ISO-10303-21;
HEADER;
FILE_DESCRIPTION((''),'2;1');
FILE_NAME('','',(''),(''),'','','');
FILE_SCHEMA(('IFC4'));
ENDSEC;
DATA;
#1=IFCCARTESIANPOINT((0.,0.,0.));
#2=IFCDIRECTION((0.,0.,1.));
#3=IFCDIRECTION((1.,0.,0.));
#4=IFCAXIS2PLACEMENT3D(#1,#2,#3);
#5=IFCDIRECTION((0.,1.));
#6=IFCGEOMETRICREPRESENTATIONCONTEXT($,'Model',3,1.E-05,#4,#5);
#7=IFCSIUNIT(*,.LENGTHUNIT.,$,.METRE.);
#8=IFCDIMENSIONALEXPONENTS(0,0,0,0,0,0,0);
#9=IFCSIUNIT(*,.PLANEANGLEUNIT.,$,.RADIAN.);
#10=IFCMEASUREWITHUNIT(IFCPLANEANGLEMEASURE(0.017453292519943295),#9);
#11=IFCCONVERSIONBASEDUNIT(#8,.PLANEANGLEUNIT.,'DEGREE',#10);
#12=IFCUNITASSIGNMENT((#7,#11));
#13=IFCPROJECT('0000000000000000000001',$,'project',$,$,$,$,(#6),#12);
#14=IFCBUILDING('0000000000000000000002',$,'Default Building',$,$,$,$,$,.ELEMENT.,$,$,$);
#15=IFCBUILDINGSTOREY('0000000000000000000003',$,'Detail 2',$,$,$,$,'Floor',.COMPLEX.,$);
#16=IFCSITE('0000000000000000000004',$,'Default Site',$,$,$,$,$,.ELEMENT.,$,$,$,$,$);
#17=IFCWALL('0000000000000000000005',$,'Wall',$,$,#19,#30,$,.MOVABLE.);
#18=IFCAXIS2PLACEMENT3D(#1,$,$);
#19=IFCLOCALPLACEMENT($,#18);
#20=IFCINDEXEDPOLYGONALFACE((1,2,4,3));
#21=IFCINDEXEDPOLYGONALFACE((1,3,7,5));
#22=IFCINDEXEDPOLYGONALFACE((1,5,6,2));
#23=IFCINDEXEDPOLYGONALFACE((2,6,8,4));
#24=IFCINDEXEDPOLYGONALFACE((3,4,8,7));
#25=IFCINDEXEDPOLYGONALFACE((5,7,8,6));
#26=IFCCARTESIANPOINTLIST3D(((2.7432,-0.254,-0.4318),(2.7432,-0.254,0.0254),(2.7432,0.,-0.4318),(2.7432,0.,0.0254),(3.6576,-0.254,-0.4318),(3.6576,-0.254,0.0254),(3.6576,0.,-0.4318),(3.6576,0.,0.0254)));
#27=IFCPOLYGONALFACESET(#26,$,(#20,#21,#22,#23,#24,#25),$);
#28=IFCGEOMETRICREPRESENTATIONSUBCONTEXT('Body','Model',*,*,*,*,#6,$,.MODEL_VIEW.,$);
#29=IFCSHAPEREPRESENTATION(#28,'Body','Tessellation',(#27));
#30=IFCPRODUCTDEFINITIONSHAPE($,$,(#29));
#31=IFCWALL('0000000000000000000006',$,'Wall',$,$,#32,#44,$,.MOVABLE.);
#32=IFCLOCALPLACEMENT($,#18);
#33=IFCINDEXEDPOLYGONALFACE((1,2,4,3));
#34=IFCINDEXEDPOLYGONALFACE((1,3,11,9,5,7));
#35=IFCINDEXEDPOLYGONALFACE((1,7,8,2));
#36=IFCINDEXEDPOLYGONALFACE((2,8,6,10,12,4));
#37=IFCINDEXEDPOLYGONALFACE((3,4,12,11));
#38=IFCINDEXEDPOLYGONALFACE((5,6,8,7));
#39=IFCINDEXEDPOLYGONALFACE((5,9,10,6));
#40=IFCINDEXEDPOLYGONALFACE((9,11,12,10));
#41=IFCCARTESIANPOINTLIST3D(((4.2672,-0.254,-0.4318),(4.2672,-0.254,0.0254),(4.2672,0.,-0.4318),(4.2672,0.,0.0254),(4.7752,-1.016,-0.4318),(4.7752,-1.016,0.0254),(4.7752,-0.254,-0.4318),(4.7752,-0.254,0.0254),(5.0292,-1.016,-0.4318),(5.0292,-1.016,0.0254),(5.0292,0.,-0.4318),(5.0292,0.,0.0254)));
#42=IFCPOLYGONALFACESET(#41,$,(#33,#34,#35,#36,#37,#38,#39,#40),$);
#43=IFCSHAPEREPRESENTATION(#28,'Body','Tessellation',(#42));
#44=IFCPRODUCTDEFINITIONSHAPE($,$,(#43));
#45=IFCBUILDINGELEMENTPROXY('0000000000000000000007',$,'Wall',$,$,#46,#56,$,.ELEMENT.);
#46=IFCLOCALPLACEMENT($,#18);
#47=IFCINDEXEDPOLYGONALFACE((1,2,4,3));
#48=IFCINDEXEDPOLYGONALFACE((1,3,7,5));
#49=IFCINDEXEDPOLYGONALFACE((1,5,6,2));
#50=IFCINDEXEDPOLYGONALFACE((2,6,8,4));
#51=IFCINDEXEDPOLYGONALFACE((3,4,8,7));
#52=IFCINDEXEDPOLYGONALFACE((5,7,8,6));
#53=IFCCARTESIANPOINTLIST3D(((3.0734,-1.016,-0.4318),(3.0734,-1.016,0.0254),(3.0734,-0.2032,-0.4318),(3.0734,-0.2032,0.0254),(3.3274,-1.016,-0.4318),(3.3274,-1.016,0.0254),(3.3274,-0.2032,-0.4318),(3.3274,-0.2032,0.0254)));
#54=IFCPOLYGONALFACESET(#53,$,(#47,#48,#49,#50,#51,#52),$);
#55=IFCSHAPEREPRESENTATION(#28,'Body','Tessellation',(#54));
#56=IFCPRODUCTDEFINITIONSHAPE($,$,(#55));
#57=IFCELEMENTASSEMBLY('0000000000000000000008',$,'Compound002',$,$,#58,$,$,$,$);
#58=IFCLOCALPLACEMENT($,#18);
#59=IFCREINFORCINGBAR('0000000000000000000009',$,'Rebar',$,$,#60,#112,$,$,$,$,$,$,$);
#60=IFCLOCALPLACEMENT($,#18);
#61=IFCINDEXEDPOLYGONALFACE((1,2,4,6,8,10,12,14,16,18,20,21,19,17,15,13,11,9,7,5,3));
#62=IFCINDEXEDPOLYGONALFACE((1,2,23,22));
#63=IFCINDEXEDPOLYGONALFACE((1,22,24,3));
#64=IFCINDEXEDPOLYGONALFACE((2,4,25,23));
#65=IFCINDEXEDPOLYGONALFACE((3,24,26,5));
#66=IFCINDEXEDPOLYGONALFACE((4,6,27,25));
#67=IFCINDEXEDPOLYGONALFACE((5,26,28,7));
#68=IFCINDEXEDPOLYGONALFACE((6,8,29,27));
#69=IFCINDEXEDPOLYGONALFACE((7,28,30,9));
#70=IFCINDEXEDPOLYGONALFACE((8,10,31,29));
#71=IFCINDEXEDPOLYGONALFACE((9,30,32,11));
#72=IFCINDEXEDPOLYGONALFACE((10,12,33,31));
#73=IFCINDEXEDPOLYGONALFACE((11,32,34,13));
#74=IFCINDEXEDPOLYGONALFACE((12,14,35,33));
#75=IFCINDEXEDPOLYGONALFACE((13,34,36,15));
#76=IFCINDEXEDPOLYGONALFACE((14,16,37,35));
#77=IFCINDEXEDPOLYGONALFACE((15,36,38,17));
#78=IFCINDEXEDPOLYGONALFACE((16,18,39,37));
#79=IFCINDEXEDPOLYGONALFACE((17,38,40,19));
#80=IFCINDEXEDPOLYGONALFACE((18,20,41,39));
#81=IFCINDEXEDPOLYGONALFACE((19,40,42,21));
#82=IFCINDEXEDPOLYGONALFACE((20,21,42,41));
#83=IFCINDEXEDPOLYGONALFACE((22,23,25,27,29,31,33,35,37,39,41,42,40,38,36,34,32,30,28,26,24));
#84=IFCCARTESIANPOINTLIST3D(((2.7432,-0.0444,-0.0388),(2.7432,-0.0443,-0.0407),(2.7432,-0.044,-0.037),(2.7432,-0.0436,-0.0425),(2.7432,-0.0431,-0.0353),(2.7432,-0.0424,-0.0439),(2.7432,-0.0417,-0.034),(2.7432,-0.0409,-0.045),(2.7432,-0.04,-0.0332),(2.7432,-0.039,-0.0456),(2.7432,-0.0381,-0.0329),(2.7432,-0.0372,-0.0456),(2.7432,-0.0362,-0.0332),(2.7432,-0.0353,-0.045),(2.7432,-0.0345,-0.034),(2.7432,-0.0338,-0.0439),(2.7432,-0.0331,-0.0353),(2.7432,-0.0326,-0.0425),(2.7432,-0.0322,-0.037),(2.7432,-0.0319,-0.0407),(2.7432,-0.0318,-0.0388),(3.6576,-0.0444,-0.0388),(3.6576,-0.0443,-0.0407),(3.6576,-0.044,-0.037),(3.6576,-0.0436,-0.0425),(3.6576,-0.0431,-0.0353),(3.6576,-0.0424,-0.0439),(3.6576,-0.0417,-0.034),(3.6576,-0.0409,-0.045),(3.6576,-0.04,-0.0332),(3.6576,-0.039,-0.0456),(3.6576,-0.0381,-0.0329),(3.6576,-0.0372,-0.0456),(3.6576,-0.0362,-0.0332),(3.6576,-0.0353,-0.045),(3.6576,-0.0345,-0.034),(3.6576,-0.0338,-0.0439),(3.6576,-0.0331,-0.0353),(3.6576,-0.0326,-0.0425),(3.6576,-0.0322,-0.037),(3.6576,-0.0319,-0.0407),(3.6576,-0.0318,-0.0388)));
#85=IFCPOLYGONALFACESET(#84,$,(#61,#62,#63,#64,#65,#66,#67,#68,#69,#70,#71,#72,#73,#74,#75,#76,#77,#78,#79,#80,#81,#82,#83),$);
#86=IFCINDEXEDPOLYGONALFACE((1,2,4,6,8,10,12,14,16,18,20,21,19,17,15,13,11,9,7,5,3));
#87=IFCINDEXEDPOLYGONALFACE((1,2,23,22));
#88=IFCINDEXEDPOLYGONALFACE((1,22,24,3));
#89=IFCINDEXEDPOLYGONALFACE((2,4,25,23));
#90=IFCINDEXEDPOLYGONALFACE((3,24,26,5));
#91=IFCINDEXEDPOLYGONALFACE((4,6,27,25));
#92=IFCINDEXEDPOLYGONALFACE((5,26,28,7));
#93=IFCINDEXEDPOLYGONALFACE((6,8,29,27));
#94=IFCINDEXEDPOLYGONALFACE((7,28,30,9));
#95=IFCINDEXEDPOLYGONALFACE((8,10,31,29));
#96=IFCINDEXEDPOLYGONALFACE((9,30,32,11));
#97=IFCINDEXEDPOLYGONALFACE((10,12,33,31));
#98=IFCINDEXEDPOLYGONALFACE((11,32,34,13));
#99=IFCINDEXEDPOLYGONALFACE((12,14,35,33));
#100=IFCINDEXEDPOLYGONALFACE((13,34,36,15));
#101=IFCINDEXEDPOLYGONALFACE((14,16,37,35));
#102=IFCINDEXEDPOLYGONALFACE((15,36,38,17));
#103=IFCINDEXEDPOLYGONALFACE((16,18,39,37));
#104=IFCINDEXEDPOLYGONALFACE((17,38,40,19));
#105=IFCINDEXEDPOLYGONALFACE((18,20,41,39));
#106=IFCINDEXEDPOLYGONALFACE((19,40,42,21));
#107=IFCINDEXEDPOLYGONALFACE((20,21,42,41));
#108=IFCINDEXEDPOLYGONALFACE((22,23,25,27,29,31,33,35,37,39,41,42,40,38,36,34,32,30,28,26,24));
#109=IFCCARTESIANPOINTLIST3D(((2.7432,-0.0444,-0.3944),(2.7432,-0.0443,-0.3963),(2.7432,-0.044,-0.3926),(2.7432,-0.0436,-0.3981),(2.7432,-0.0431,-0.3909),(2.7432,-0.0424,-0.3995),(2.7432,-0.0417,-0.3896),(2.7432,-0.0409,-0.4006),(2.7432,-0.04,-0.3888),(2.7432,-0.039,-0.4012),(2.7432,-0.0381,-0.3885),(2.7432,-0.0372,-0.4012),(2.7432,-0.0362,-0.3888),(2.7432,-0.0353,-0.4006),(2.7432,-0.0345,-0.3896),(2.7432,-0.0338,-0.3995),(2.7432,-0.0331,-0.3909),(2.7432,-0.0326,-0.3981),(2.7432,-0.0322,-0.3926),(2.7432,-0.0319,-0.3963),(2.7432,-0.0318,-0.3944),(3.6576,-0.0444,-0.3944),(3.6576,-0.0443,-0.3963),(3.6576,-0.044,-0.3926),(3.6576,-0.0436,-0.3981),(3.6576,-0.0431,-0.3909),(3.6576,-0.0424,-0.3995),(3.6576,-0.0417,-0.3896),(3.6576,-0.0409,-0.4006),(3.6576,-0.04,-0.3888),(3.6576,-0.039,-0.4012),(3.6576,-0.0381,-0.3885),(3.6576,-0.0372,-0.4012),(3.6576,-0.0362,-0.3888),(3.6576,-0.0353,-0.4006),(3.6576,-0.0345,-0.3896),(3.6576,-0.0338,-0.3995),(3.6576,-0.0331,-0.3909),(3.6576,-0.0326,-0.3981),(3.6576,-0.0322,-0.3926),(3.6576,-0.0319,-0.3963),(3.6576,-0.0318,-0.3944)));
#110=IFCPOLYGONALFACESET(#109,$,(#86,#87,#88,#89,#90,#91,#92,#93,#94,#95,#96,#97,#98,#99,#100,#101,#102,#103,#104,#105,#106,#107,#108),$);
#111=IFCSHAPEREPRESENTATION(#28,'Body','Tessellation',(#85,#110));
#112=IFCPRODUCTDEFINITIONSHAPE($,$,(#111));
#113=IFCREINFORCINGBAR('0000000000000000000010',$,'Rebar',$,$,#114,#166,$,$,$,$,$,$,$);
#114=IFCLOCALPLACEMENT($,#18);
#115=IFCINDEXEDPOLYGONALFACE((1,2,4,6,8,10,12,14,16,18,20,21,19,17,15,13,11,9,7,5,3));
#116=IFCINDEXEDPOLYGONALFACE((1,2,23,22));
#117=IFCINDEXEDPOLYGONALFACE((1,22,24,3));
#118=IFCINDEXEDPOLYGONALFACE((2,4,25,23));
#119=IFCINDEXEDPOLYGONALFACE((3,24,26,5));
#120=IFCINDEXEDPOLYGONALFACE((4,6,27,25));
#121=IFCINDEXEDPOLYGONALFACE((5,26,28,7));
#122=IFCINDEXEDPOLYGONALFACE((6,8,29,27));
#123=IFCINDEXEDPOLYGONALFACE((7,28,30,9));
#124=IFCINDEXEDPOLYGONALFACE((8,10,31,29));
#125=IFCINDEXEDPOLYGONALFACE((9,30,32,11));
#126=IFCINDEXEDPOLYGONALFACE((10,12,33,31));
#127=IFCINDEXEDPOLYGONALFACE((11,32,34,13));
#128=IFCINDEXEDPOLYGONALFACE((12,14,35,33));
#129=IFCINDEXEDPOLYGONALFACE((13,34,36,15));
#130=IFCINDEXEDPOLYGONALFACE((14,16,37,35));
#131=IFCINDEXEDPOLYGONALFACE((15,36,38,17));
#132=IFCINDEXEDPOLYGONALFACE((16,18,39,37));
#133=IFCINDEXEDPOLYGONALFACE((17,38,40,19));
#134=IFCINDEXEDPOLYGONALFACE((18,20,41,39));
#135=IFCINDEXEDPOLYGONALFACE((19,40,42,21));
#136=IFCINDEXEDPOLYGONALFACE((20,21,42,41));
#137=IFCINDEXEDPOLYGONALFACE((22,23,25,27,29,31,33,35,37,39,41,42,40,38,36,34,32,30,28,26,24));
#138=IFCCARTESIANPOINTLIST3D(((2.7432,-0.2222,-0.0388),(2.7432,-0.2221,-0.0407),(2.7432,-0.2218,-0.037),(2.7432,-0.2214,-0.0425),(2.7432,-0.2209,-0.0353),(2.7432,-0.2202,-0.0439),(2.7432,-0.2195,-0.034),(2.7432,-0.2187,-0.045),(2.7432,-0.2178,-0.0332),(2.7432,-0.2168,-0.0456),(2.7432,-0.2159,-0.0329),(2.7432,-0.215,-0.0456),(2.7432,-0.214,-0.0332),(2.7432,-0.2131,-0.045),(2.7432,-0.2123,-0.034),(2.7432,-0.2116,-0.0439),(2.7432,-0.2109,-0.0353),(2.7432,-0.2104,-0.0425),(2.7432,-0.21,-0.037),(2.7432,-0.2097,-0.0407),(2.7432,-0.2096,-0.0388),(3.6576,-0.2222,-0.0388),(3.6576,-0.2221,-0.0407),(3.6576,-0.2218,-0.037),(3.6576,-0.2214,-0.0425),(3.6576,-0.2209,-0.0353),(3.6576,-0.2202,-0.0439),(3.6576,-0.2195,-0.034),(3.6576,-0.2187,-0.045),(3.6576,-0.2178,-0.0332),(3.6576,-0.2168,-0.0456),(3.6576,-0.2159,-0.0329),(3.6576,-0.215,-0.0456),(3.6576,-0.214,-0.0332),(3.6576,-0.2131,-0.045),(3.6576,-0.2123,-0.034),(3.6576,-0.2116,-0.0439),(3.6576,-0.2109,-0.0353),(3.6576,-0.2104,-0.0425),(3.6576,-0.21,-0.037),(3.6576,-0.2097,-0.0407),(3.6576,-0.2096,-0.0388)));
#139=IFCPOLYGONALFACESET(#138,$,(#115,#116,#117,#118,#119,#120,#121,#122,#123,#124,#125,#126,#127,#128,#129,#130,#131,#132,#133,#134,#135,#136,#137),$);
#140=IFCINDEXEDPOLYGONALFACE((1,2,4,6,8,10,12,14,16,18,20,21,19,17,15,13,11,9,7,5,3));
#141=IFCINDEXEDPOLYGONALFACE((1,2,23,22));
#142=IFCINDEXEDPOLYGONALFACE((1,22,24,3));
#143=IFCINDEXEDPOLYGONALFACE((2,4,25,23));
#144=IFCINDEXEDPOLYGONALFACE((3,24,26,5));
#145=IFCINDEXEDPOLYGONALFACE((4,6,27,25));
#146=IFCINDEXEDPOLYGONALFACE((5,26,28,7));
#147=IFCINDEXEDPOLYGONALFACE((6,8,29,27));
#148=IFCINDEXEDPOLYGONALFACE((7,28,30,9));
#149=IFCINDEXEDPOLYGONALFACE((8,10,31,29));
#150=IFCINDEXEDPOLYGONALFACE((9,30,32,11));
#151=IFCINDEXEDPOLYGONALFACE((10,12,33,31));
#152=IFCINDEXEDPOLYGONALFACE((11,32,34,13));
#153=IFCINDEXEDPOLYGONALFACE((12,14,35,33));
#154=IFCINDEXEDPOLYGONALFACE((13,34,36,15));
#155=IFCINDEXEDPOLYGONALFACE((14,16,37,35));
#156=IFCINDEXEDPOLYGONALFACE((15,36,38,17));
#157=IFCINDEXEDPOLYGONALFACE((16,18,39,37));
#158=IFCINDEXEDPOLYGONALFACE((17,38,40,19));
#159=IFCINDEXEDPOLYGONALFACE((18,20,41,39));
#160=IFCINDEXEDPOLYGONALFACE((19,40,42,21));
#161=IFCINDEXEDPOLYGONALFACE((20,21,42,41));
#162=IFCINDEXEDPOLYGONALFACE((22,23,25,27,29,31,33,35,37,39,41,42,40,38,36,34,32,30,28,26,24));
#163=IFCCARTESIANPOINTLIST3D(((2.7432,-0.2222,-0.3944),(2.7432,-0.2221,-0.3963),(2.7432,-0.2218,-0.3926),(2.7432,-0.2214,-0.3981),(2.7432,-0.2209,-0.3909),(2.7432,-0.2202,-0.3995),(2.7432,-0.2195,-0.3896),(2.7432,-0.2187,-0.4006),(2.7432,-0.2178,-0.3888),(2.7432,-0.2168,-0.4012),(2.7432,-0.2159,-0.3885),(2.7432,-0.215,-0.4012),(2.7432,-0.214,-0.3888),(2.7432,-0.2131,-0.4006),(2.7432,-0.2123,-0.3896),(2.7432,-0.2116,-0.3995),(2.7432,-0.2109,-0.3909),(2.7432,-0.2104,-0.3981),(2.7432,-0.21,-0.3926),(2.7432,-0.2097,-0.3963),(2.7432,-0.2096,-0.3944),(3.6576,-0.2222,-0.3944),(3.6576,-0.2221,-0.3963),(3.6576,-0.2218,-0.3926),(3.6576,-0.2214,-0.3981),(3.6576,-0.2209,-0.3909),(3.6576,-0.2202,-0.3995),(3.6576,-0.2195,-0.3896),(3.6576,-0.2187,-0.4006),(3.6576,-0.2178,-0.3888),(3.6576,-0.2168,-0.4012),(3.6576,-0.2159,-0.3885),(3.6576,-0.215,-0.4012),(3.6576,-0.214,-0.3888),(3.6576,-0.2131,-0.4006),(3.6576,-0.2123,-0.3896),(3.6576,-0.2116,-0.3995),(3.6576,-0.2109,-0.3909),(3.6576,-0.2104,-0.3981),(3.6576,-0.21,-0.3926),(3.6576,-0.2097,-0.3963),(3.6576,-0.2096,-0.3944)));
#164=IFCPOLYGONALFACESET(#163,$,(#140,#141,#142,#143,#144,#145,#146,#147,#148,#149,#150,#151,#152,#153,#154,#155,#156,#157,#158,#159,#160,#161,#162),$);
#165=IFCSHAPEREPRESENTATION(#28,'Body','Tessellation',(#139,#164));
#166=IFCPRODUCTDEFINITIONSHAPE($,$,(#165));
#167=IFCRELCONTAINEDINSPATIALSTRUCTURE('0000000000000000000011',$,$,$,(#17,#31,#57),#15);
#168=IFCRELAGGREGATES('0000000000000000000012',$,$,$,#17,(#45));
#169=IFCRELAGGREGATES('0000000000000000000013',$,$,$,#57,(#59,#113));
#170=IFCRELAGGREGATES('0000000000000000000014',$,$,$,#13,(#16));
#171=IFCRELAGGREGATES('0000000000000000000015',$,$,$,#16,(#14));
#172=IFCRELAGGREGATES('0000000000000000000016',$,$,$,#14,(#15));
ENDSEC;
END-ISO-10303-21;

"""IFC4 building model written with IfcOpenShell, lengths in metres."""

from ifc_helpers import new_model, entity, si_unit, converted_unit, direction, frame, frame_2d, origin_with_axes, origin_2d_with_axis, place, context, subcontext, project, spatial, polyline, rectangle, outline, extrude, element, aggregate, save


model = new_model("IFC4")

# Units and contexts
model_context = context("Model", 3, precision=1e-05, world=origin_with_axes(), true_north=direction((0.0, 1.0)))
body_context = subcontext(model_context, "Body", "Model", "MODEL_VIEW")
ifc_project = project(units=[si_unit("LENGTHUNIT", "METRE"), converted_unit("PLANEANGLEUNIT", "DEGREE", entity("IfcPlaneAngleMeasure", 0.017453292519943295), si_unit("PLANEANGLEUNIT", "RADIAN"), dimensions=[0, 0, 0, 0, 0, 0, 0])], contexts=[model_context])

# Site, building, storey
site = spatial("IfcSite", under=ifc_project, Name="Default Site", CompositionType="ELEMENT")
building = spatial("IfcBuilding", under=site, Name="Default Building", CompositionType="ELEMENT")
storey = spatial("IfcBuildingStorey", under=building, Name="Detail 2", LongName="Floor", CompositionType="COMPLEX")

# Walls
placement = place(None, origin_with_axes())
wall_1 = element("IfcWall", 1, at=placement, inside=storey, Name="Wall", PredefinedType="MOVABLE", context=body_context, shape_type="SweptSolid", body=[
    extrude(rectangle(XDim=0.9144, YDim=0.254, at=origin_2d_with_axis()), frame((3.2004, -0.127, 0.0254), z_axis=(0.0, 0.0, 1.0), x_axis=(1.0, 0.0, 0.0)), (0.0, 0.0, -1.0), 0.4572),
])
element("IfcWall", 2, at=placement, inside=storey, Name="Wall", PredefinedType="MOVABLE", context=body_context, shape_type="SweptSolid", body=[
    extrude(outline(polyline([(-0.508, 0.381), (0.254, 0.381), (0.254, -0.635), (0.0, -0.635), (0.0, 0.127), (-0.508, 0.127), (-0.508, 0.381)])), frame((4.7752, -0.381, 0.0254), z_axis=(0.0, 0.0, 1.0), x_axis=(1.0, 0.0, 0.0)), (0.0, 0.0, -1.0), 0.4572),
])

# Building element proxy
proxy = element("IfcBuildingElementProxy", 3, at=placement, Name="Wall", PredefinedType="ELEMENT", context=body_context, shape_type="SweptSolid", body=[
    extrude(rectangle(XDim=0.8128, YDim=0.254, at=frame_2d((0.0, 0.0), x_axis=(0.0, 1.0))), frame((3.2004, -0.6096, 0.0254), z_axis=(0.0, 0.0, 1.0), x_axis=(1.0, 0.0, 0.0)), (0.0, 0.0, -1.0), 0.4572),
])
aggregate(wall_1, [proxy])

# Element assembly, reinforcing bars
assembly_1 = element("IfcElementAssembly", 4, inside=storey, Name="Compound002")
reinforcing_bar_1 = element("IfcReinforcingBar", 5, at=placement, Name="Rebar", context=body_context, shape_type="SweptSolid", body=[
    entity("IfcSweptDiskSolid", entity("IfcCompositeCurve", [entity("IfcCompositeCurveSegment", "CONTINUOUS", True, entity("IfcPolyline", [entity("IfcCartesianPoint", [2.7432, -0.0381, -0.0393]), entity("IfcCartesianPoint", [3.6576, -0.0381, -0.0393])]))], False), 0.0063),
    entity("IfcSweptDiskSolid", entity("IfcCompositeCurve", [entity("IfcCompositeCurveSegment", "CONTINUOUS", True, entity("IfcPolyline", [entity("IfcCartesianPoint", [2.7432, -0.0381, -0.3949]), entity("IfcCartesianPoint", [3.6576, -0.0381, -0.3949])]))], False), 0.0063),
])
reinforcing_bar_2 = element("IfcReinforcingBar", 6, at=placement, Name="Rebar", context=body_context, shape_type="SweptSolid", body=[
    entity("IfcSweptDiskSolid", entity("IfcCompositeCurve", [entity("IfcCompositeCurveSegment", "CONTINUOUS", True, entity("IfcPolyline", [entity("IfcCartesianPoint", [2.7432, -0.2159, -0.0393]), entity("IfcCartesianPoint", [3.6576, -0.2159, -0.0393])]))], False), 0.0063),
    entity("IfcSweptDiskSolid", entity("IfcCompositeCurve", [entity("IfcCompositeCurveSegment", "CONTINUOUS", True, entity("IfcPolyline", [entity("IfcCartesianPoint", [2.7432, -0.2159, -0.3949]), entity("IfcCartesianPoint", [3.6576, -0.2159, -0.3949])]))], False), 0.0063),
])
aggregate(assembly_1, [reinforcing_bar_1, reinforcing_bar_2])

save(model, "model.ifc")
